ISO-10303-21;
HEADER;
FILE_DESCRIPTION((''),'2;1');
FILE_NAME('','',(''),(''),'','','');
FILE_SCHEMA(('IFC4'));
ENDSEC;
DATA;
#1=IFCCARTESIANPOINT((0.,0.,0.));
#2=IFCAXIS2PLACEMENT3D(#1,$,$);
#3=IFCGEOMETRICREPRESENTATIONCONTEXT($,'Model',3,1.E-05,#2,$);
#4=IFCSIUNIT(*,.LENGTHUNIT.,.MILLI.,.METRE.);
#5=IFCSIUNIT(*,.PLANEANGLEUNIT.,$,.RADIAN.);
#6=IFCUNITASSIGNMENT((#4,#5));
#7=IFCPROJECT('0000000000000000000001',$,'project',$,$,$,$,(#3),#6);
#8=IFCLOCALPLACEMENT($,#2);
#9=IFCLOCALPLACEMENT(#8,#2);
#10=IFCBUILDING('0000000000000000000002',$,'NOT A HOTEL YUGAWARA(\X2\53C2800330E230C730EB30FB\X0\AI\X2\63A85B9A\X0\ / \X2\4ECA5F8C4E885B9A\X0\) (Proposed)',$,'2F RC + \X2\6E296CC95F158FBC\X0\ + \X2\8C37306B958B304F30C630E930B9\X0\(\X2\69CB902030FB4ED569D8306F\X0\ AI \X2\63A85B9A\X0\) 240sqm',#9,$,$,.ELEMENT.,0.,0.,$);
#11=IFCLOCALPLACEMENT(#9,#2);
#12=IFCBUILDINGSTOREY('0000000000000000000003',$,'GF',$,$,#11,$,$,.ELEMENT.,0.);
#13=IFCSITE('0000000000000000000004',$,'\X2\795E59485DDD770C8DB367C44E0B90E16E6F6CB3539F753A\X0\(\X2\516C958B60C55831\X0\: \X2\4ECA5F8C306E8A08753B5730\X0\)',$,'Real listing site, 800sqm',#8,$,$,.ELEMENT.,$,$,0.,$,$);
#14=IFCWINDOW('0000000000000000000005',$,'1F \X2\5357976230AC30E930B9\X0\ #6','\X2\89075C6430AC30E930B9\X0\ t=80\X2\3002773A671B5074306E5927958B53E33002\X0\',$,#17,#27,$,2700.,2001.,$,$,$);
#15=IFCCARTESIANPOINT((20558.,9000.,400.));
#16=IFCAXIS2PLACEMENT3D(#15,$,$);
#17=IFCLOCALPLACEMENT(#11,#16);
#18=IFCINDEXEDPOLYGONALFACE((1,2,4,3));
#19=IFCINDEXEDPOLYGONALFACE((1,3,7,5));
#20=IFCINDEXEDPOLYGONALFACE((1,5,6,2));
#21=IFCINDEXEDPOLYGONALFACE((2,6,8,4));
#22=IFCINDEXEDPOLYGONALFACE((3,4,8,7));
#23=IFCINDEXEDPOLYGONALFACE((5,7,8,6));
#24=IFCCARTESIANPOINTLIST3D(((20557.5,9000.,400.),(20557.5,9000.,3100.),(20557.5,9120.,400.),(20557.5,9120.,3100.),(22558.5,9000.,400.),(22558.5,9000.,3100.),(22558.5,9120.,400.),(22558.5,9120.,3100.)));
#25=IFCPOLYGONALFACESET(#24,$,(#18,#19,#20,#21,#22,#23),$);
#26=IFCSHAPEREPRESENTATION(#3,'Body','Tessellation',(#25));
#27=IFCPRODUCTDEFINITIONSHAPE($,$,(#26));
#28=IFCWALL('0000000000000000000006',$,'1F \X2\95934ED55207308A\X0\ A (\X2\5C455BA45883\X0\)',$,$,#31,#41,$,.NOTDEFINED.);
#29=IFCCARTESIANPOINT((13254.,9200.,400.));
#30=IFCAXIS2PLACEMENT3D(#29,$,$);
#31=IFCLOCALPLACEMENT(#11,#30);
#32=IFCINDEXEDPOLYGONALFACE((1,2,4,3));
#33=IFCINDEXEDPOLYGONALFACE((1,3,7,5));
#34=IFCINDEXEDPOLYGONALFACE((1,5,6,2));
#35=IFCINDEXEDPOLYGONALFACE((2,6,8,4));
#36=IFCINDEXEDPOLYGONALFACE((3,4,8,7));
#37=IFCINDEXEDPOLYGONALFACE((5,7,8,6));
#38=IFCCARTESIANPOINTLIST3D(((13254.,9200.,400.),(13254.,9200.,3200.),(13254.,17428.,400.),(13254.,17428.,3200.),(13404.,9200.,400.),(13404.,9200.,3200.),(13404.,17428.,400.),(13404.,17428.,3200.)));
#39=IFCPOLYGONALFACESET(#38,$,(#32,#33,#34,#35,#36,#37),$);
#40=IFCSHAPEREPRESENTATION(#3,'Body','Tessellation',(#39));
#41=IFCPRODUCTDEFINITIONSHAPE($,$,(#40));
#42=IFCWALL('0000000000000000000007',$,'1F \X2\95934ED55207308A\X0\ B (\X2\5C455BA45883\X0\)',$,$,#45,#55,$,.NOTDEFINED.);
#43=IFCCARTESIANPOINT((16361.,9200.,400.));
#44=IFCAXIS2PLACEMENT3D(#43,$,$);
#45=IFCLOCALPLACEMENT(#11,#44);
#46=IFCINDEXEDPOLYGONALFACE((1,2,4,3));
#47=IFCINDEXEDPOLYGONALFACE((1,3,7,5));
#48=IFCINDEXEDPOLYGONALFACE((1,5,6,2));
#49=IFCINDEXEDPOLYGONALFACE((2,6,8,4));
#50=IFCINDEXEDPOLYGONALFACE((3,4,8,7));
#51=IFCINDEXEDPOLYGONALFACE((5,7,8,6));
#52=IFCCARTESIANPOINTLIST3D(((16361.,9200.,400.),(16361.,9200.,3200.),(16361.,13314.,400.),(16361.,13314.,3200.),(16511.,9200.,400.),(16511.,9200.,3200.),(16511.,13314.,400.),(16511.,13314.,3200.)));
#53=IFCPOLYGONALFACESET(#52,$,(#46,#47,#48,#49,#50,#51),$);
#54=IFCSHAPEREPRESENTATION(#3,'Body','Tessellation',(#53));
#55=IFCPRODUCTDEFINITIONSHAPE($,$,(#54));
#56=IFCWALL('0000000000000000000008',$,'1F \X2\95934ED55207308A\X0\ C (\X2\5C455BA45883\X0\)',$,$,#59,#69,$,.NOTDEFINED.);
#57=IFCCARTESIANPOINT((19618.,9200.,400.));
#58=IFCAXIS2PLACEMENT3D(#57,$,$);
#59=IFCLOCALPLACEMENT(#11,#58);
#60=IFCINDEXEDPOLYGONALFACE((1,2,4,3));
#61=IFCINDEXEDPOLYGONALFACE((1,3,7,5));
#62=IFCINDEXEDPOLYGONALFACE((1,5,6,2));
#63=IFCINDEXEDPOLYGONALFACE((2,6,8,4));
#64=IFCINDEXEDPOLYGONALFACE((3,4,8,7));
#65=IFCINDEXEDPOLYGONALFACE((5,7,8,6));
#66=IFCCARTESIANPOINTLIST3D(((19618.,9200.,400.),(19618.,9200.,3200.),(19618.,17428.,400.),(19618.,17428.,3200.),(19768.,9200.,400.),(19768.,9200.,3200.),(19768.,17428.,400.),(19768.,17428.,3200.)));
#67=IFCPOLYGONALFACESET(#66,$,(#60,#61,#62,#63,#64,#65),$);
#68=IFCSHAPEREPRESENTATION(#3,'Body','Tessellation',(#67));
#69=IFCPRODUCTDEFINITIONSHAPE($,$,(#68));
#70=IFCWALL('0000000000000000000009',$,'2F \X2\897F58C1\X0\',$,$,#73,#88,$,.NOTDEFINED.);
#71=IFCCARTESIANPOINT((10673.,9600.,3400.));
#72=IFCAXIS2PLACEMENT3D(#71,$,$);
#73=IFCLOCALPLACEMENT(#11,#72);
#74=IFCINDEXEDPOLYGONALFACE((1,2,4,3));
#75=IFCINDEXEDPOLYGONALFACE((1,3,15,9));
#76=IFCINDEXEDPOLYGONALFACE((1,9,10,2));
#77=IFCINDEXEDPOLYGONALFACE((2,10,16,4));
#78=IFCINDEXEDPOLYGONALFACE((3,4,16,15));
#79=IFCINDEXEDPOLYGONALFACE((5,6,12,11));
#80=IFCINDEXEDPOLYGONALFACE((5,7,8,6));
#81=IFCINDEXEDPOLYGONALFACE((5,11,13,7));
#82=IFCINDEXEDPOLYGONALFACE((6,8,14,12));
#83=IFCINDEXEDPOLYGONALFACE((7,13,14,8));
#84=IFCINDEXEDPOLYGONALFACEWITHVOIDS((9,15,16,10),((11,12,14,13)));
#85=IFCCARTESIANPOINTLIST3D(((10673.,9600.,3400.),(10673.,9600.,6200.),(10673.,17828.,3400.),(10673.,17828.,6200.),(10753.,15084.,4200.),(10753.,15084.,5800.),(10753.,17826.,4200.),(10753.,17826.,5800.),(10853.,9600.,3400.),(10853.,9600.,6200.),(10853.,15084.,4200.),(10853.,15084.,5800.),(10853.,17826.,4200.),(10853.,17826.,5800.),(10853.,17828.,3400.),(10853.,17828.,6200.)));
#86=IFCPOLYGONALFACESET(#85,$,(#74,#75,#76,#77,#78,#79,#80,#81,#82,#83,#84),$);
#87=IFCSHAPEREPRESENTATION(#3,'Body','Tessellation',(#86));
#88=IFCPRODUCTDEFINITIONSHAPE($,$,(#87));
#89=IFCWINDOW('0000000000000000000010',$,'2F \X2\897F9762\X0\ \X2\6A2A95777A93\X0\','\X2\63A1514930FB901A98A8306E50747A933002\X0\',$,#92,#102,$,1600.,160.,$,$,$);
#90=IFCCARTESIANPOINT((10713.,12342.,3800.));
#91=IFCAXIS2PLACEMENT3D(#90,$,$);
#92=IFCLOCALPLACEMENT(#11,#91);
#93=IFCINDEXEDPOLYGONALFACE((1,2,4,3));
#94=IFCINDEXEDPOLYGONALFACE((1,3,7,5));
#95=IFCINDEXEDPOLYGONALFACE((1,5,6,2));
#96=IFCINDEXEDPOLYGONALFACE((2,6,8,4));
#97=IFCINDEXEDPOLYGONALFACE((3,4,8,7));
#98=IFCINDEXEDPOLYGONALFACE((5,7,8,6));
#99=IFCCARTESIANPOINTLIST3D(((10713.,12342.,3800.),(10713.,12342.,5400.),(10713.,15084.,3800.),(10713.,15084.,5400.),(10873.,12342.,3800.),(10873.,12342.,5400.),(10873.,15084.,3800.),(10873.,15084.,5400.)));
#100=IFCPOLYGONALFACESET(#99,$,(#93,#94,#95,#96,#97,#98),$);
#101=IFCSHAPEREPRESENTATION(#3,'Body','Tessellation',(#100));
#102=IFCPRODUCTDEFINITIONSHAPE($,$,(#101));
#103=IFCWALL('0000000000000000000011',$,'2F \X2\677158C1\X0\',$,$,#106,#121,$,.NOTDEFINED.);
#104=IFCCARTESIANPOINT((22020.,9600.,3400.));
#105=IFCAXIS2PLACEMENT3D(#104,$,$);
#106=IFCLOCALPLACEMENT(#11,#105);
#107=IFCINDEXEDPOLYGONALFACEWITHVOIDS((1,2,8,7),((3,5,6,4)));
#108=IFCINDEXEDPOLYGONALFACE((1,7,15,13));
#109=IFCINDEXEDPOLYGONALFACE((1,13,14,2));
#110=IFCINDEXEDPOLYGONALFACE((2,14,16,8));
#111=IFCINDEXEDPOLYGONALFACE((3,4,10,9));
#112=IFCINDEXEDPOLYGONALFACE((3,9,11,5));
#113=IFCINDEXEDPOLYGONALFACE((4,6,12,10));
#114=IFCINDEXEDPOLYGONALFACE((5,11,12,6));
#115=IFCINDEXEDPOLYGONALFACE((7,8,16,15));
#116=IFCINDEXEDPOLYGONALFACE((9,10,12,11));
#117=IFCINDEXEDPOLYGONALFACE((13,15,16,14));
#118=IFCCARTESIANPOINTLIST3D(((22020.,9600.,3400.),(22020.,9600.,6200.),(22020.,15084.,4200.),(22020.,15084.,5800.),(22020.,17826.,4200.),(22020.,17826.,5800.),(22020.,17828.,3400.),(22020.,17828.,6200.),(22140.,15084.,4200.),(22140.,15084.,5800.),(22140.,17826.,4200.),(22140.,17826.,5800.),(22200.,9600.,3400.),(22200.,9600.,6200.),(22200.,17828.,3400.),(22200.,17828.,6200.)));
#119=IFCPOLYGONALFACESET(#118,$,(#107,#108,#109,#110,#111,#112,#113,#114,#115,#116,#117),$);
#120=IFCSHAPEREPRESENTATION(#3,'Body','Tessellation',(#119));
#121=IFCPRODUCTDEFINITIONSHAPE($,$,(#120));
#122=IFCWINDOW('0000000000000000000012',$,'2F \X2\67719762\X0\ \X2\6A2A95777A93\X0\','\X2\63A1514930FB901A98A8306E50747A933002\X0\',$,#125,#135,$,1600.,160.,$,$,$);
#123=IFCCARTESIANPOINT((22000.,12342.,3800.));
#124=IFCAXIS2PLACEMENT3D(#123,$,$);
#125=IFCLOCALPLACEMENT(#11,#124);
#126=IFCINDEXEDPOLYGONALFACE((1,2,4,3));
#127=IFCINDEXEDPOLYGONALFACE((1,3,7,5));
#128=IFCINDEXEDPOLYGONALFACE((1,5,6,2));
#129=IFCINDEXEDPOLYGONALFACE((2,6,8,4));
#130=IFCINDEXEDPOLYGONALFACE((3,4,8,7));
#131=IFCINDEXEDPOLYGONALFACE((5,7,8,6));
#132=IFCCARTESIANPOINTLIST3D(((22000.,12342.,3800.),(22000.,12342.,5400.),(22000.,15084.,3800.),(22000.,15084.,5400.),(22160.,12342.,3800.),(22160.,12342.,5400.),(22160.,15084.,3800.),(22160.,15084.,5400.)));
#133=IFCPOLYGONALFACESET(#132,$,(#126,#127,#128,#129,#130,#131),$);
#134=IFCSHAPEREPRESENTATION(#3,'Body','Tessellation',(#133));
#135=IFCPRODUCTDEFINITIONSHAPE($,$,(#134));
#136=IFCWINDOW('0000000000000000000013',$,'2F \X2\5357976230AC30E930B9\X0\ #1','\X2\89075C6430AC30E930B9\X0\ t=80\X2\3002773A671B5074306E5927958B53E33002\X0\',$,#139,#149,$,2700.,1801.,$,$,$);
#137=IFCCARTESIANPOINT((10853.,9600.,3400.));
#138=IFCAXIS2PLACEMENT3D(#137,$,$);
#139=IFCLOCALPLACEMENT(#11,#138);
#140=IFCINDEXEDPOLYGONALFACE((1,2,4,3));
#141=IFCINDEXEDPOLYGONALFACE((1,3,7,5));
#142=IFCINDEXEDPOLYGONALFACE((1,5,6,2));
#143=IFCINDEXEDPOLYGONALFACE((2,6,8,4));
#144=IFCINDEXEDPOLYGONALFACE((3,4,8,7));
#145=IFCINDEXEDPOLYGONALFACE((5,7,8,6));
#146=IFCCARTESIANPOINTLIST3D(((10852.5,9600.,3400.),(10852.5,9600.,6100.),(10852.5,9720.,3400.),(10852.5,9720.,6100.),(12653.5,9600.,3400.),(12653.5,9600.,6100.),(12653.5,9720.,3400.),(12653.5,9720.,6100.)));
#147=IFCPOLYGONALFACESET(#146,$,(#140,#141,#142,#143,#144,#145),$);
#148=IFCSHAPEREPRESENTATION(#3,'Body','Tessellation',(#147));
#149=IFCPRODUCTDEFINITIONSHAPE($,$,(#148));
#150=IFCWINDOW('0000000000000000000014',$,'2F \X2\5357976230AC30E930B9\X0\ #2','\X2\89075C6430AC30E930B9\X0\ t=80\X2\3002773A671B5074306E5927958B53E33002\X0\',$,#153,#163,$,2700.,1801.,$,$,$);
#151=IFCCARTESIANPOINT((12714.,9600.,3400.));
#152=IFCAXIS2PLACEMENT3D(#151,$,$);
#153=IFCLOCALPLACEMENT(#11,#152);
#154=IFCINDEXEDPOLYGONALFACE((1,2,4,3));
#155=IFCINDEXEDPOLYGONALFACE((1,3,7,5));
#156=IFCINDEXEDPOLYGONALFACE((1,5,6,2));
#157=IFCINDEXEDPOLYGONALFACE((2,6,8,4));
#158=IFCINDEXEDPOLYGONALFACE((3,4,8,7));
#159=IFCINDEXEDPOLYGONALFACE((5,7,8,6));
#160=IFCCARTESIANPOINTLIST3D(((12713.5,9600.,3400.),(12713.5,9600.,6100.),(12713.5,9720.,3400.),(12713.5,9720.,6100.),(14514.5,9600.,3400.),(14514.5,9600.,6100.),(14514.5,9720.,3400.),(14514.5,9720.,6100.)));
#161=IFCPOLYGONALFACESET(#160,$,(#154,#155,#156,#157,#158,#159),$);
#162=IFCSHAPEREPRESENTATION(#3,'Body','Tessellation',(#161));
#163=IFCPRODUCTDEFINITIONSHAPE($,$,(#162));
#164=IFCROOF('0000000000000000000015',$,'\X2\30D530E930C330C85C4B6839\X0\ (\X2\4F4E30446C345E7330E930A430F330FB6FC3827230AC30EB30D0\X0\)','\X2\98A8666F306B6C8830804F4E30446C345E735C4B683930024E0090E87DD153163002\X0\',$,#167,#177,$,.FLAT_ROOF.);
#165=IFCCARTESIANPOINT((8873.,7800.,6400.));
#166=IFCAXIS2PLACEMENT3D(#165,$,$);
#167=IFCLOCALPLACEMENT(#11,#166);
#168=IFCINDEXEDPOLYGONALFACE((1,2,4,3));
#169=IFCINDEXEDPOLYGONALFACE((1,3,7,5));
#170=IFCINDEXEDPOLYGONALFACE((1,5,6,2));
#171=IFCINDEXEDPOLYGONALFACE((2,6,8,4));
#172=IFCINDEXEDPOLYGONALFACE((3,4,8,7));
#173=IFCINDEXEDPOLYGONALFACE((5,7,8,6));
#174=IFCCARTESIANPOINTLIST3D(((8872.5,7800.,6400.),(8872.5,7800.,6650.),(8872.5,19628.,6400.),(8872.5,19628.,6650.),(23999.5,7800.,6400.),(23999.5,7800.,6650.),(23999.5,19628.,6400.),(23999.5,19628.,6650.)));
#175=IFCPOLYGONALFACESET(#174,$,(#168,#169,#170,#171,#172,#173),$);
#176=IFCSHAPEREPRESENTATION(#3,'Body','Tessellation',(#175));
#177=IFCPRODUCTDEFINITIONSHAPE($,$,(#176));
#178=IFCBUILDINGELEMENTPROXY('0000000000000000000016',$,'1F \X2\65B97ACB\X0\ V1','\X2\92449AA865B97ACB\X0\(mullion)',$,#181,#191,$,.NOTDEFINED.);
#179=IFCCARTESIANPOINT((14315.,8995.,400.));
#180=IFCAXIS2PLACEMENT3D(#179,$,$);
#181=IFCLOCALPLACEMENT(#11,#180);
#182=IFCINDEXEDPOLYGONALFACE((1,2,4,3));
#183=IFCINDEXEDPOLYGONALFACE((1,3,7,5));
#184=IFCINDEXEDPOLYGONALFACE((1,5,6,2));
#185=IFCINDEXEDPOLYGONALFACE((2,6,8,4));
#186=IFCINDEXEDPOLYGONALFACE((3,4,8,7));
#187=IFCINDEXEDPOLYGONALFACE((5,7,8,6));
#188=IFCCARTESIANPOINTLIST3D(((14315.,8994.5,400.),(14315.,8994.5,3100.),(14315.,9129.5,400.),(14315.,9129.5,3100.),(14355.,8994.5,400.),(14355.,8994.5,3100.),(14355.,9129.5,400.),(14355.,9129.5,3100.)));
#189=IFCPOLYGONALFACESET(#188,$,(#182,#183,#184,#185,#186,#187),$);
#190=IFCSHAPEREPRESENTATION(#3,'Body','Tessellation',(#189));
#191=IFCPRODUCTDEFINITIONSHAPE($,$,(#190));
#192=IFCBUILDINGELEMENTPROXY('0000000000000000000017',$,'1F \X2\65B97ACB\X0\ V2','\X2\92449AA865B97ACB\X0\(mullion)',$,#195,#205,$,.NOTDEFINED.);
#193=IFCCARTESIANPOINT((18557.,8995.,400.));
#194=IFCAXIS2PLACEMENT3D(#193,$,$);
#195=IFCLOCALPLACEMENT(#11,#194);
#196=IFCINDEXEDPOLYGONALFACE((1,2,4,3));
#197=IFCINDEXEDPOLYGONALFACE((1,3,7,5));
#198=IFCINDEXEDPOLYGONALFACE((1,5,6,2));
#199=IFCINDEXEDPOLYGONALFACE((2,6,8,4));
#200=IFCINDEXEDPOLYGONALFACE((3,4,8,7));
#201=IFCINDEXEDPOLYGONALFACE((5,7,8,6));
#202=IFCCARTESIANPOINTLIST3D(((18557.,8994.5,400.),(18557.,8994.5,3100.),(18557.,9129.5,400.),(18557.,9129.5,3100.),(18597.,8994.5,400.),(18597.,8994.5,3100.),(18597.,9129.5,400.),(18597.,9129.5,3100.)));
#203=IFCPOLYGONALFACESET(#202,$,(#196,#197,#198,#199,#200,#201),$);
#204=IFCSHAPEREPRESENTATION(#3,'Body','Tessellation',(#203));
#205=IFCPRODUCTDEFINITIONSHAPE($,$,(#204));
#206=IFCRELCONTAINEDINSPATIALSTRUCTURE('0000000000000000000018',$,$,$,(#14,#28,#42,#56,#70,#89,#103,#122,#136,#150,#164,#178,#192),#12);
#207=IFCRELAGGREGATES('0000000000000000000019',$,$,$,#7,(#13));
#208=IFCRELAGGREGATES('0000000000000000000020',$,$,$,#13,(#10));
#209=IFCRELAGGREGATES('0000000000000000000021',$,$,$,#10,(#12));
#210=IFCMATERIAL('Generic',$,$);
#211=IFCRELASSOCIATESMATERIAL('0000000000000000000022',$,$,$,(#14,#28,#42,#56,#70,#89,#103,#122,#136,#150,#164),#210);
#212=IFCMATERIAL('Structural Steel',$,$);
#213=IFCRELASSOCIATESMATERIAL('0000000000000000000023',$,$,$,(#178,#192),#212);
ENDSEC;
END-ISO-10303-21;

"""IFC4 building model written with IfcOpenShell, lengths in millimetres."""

from ifc_helpers import new_model, si_unit, frame, frame_2d, origin, place, context, project, spatial, rectangle, extrude, material, element, fill, save


model = new_model("IFC4")

# Units and contexts
model_context = context("Model", 3, precision=1e-05, world=origin())
ifc_project = project(units=[si_unit("LENGTHUNIT", "METRE", prefix="MILLI"), si_unit("PLANEANGLEUNIT", "RADIAN")], contexts=[model_context])

# Site, building, storey
site_placement = place(None, origin())
site = spatial("IfcSite", under=ifc_project, at=site_placement, Name="神奈川県足柄下郡湯河原町(公開情報: 今後の計画地)", ObjectType="Real listing site, 800sqm", CompositionType="ELEMENT", RefElevation=0.0)
building_placement = place(site_placement, origin())
building = spatial("IfcBuilding", under=site, at=building_placement, Name="NOT A HOTEL YUGAWARA(参考モデル・AI推定 / 今後予定) (Proposed)", ObjectType="2F RC + 温泉引込 + 谷に開くテラス(構造・仕様は AI 推定) 240sqm", CompositionType="ELEMENT", ElevationOfRefHeight=0.0, ElevationOfTerrain=0.0)
storey_placement = place(building_placement, origin())
storey = spatial("IfcBuildingStorey", under=building, at=storey_placement, Name="GF", CompositionType="ELEMENT", Elevation=0.0)

# Shared definitions
ifc_material_1 = material(Name="Generic")

# Window
window_1_placement = place(storey_placement, frame((20558.0, 9000.0, 400.0)))
element("IfcWindow", 1, at=window_1_placement, inside=storey, material=ifc_material_1, Name="1F 南面ガラス #6", Description="複層ガラス t=80。眺望側の大開口。", OverallHeight=2700.0, OverallWidth=2001.0, context=model_context, shape_type="SweptSolid", body=[
    extrude(rectangle(XDim=2001.0, YDim=120.0, at=frame_2d((1000.0, 60.0))), frame((20558.0, 9000.0, 400.0)), (0.0, 0.0, 1.0), 2700.0),
])

# Walls
wall_1_placement = place(storey_placement, frame((13254.0, 9200.0, 400.0)))
element("IfcWall", 2, at=wall_1_placement, inside=storey, material=ifc_material_1, Name="1F 間仕切り A (居室境)", PredefinedType="NOTDEFINED", context=model_context, shape_type="SweptSolid", body=[
    extrude(rectangle(XDim=150.0, YDim=8228.0, at=frame_2d((75.0, 4114.0))), frame((13254.0, 9200.0, 400.0)), (0.0, 0.0, 1.0), 2800.0),
])
wall_2_placement = place(storey_placement, frame((16361.0, 9200.0, 400.0)))
element("IfcWall", 3, at=wall_2_placement, inside=storey, material=ifc_material_1, Name="1F 間仕切り B (居室境)", PredefinedType="NOTDEFINED", context=model_context, shape_type="SweptSolid", body=[
    extrude(rectangle(XDim=150.0, YDim=4114.0, at=frame_2d((75.0, 2057.0))), frame((16361.0, 9200.0, 400.0)), (0.0, 0.0, 1.0), 2800.0),
])
wall_3_placement = place(storey_placement, frame((19618.0, 9200.0, 400.0)))
element("IfcWall", 4, at=wall_3_placement, inside=storey, material=ifc_material_1, Name="1F 間仕切り C (居室境)", PredefinedType="NOTDEFINED", context=model_context, shape_type="SweptSolid", body=[
    extrude(rectangle(XDim=150.0, YDim=8228.0, at=frame_2d((75.0, 4114.0))), frame((19618.0, 9200.0, 400.0)), (0.0, 0.0, 1.0), 2800.0),
])

# Walls, openings, windows
wall_4_placement = place(storey_placement, frame((10673.0, 9600.0, 3400.0)))
wall_4 = element("IfcWall", 5, at=wall_4_placement, inside=storey, material=ifc_material_1, Name="2F 西壁", PredefinedType="NOTDEFINED", context=model_context, shape_type="SweptSolid", body=[
    extrude(rectangle(XDim=180.0, YDim=8228.0, at=frame_2d((90.0, 4114.0))), frame((10673.0, 9600.0, 3400.0)), (0.0, 0.0, 1.0), 2800.0),
])
opening_1_placement = place(storey_placement, frame((10713.0, 12342.0, 3800.0)))
opening_1 = element("IfcOpeningElement", 6, at=opening_1_placement, cuts=wall_4, PredefinedType="NOTDEFINED", context=model_context, shape_type="SweptSolid", body=[
    extrude(rectangle(XDim=160.0, YDim=2742.0, at=frame_2d((80.0, 1371.0))), frame((10713.0, 12342.0, 3800.0)), (0.0, 0.0, 1.0), 1600.0),
])
window_2_placement = place(storey_placement, frame((10713.0, 12342.0, 3800.0)))
window_2 = element("IfcWindow", 7, at=window_2_placement, inside=storey, material=ifc_material_1, Name="2F 西面 横長窓", Description="採光・通風の側窓。", OverallHeight=1600.0, OverallWidth=160.0, context=model_context, shape_type="SweptSolid", body=[
    extrude(rectangle(XDim=160.0, YDim=2742.0, at=frame_2d((80.0, 1371.0))), frame((10713.0, 12342.0, 3800.0)), (0.0, 0.0, 1.0), 1600.0),
])
fill(opening_1, window_2)
wall_5_placement = place(storey_placement, frame((22020.0, 9600.0, 3400.0)))
wall_5 = element("IfcWall", 8, at=wall_5_placement, inside=storey, material=ifc_material_1, Name="2F 東壁", PredefinedType="NOTDEFINED", context=model_context, shape_type="SweptSolid", body=[
    extrude(rectangle(XDim=180.0, YDim=8228.0, at=frame_2d((90.0, 4114.0))), frame((22020.0, 9600.0, 3400.0)), (0.0, 0.0, 1.0), 2800.0),
])
opening_2_placement = place(storey_placement, frame((22000.0, 12342.0, 3800.0)))
opening_2 = element("IfcOpeningElement", 9, at=opening_2_placement, cuts=wall_5, PredefinedType="NOTDEFINED", context=model_context, shape_type="SweptSolid", body=[
    extrude(rectangle(XDim=160.0, YDim=2742.0, at=frame_2d((80.0, 1371.0))), frame((22000.0, 12342.0, 3800.0)), (0.0, 0.0, 1.0), 1600.0),
])
window_3_placement = place(storey_placement, frame((22000.0, 12342.0, 3800.0)))
window_3 = element("IfcWindow", 10, at=window_3_placement, inside=storey, material=ifc_material_1, Name="2F 東面 横長窓", Description="採光・通風の側窓。", OverallHeight=1600.0, OverallWidth=160.0, context=model_context, shape_type="SweptSolid", body=[
    extrude(rectangle(XDim=160.0, YDim=2742.0, at=frame_2d((80.0, 1371.0))), frame((22000.0, 12342.0, 3800.0)), (0.0, 0.0, 1.0), 1600.0),
])
fill(opening_2, window_3)

# Windows
window_4_placement = place(storey_placement, frame((10853.0, 9600.0, 3400.0)))
element("IfcWindow", 11, at=window_4_placement, inside=storey, material=ifc_material_1, Name="2F 南面ガラス #1", Description="複層ガラス t=80。眺望側の大開口。", OverallHeight=2700.0, OverallWidth=1801.0, context=model_context, shape_type="SweptSolid", body=[
    extrude(rectangle(XDim=1801.0, YDim=120.0, at=frame_2d((900.0, 60.0))), frame((10853.0, 9600.0, 3400.0)), (0.0, 0.0, 1.0), 2700.0),
])
window_5_placement = place(storey_placement, frame((12714.0, 9600.0, 3400.0)))
element("IfcWindow", 12, at=window_5_placement, inside=storey, material=ifc_material_1, Name="2F 南面ガラス #2", Description="複層ガラス t=80。眺望側の大開口。", OverallHeight=2700.0, OverallWidth=1801.0, context=model_context, shape_type="SweptSolid", body=[
    extrude(rectangle(XDim=1801.0, YDim=120.0, at=frame_2d((900.0, 60.0))), frame((12714.0, 9600.0, 3400.0)), (0.0, 0.0, 1.0), 2700.0),
])

# Roof
roof_placement = place(storey_placement, frame((8873.0, 7800.0, 6400.0)))
element("IfcRoof", 13, at=roof_placement, inside=storey, material=ifc_material_1, Name="フラット屋根 (低い水平ライン・濃色ガルバ)", Description="風景に沈む低い水平屋根。一部緑化。", PredefinedType="FLAT_ROOF", context=model_context, shape_type="SweptSolid", body=[
    extrude(rectangle(XDim=15127.0, YDim=11828.0, at=frame_2d((7563.0, 5914.0))), frame((8873.0, 7800.0, 6400.0)), (0.0, 0.0, 1.0), 250.0),
])

# Building element proxies
ifc_material_2 = material(Name="Structural Steel")
proxy_1_placement = place(storey_placement, frame((14315.0, 8995.0, 400.0)))
element("IfcBuildingElementProxy", 14, at=proxy_1_placement, inside=storey, material=ifc_material_2, Name="1F 方立 V1", Description="鉄骨方立(mullion)", PredefinedType="NOTDEFINED", context=model_context, shape_type="SweptSolid", body=[
    extrude(rectangle(XDim=40.0, YDim=135.0, at=frame_2d((20.0, 67.0))), frame((14315.0, 8995.0, 400.0)), (0.0, 0.0, 1.0), 2700.0),
])
proxy_2_placement = place(storey_placement, frame((18557.0, 8995.0, 400.0)))
element("IfcBuildingElementProxy", 15, at=proxy_2_placement, inside=storey, material=ifc_material_2, Name="1F 方立 V2", Description="鉄骨方立(mullion)", PredefinedType="NOTDEFINED", context=model_context, shape_type="SweptSolid", body=[
    extrude(rectangle(XDim=40.0, YDim=135.0, at=frame_2d((20.0, 67.0))), frame((18557.0, 8995.0, 400.0)), (0.0, 0.0, 1.0), 2700.0),
])

save(model, "model.ifc")
